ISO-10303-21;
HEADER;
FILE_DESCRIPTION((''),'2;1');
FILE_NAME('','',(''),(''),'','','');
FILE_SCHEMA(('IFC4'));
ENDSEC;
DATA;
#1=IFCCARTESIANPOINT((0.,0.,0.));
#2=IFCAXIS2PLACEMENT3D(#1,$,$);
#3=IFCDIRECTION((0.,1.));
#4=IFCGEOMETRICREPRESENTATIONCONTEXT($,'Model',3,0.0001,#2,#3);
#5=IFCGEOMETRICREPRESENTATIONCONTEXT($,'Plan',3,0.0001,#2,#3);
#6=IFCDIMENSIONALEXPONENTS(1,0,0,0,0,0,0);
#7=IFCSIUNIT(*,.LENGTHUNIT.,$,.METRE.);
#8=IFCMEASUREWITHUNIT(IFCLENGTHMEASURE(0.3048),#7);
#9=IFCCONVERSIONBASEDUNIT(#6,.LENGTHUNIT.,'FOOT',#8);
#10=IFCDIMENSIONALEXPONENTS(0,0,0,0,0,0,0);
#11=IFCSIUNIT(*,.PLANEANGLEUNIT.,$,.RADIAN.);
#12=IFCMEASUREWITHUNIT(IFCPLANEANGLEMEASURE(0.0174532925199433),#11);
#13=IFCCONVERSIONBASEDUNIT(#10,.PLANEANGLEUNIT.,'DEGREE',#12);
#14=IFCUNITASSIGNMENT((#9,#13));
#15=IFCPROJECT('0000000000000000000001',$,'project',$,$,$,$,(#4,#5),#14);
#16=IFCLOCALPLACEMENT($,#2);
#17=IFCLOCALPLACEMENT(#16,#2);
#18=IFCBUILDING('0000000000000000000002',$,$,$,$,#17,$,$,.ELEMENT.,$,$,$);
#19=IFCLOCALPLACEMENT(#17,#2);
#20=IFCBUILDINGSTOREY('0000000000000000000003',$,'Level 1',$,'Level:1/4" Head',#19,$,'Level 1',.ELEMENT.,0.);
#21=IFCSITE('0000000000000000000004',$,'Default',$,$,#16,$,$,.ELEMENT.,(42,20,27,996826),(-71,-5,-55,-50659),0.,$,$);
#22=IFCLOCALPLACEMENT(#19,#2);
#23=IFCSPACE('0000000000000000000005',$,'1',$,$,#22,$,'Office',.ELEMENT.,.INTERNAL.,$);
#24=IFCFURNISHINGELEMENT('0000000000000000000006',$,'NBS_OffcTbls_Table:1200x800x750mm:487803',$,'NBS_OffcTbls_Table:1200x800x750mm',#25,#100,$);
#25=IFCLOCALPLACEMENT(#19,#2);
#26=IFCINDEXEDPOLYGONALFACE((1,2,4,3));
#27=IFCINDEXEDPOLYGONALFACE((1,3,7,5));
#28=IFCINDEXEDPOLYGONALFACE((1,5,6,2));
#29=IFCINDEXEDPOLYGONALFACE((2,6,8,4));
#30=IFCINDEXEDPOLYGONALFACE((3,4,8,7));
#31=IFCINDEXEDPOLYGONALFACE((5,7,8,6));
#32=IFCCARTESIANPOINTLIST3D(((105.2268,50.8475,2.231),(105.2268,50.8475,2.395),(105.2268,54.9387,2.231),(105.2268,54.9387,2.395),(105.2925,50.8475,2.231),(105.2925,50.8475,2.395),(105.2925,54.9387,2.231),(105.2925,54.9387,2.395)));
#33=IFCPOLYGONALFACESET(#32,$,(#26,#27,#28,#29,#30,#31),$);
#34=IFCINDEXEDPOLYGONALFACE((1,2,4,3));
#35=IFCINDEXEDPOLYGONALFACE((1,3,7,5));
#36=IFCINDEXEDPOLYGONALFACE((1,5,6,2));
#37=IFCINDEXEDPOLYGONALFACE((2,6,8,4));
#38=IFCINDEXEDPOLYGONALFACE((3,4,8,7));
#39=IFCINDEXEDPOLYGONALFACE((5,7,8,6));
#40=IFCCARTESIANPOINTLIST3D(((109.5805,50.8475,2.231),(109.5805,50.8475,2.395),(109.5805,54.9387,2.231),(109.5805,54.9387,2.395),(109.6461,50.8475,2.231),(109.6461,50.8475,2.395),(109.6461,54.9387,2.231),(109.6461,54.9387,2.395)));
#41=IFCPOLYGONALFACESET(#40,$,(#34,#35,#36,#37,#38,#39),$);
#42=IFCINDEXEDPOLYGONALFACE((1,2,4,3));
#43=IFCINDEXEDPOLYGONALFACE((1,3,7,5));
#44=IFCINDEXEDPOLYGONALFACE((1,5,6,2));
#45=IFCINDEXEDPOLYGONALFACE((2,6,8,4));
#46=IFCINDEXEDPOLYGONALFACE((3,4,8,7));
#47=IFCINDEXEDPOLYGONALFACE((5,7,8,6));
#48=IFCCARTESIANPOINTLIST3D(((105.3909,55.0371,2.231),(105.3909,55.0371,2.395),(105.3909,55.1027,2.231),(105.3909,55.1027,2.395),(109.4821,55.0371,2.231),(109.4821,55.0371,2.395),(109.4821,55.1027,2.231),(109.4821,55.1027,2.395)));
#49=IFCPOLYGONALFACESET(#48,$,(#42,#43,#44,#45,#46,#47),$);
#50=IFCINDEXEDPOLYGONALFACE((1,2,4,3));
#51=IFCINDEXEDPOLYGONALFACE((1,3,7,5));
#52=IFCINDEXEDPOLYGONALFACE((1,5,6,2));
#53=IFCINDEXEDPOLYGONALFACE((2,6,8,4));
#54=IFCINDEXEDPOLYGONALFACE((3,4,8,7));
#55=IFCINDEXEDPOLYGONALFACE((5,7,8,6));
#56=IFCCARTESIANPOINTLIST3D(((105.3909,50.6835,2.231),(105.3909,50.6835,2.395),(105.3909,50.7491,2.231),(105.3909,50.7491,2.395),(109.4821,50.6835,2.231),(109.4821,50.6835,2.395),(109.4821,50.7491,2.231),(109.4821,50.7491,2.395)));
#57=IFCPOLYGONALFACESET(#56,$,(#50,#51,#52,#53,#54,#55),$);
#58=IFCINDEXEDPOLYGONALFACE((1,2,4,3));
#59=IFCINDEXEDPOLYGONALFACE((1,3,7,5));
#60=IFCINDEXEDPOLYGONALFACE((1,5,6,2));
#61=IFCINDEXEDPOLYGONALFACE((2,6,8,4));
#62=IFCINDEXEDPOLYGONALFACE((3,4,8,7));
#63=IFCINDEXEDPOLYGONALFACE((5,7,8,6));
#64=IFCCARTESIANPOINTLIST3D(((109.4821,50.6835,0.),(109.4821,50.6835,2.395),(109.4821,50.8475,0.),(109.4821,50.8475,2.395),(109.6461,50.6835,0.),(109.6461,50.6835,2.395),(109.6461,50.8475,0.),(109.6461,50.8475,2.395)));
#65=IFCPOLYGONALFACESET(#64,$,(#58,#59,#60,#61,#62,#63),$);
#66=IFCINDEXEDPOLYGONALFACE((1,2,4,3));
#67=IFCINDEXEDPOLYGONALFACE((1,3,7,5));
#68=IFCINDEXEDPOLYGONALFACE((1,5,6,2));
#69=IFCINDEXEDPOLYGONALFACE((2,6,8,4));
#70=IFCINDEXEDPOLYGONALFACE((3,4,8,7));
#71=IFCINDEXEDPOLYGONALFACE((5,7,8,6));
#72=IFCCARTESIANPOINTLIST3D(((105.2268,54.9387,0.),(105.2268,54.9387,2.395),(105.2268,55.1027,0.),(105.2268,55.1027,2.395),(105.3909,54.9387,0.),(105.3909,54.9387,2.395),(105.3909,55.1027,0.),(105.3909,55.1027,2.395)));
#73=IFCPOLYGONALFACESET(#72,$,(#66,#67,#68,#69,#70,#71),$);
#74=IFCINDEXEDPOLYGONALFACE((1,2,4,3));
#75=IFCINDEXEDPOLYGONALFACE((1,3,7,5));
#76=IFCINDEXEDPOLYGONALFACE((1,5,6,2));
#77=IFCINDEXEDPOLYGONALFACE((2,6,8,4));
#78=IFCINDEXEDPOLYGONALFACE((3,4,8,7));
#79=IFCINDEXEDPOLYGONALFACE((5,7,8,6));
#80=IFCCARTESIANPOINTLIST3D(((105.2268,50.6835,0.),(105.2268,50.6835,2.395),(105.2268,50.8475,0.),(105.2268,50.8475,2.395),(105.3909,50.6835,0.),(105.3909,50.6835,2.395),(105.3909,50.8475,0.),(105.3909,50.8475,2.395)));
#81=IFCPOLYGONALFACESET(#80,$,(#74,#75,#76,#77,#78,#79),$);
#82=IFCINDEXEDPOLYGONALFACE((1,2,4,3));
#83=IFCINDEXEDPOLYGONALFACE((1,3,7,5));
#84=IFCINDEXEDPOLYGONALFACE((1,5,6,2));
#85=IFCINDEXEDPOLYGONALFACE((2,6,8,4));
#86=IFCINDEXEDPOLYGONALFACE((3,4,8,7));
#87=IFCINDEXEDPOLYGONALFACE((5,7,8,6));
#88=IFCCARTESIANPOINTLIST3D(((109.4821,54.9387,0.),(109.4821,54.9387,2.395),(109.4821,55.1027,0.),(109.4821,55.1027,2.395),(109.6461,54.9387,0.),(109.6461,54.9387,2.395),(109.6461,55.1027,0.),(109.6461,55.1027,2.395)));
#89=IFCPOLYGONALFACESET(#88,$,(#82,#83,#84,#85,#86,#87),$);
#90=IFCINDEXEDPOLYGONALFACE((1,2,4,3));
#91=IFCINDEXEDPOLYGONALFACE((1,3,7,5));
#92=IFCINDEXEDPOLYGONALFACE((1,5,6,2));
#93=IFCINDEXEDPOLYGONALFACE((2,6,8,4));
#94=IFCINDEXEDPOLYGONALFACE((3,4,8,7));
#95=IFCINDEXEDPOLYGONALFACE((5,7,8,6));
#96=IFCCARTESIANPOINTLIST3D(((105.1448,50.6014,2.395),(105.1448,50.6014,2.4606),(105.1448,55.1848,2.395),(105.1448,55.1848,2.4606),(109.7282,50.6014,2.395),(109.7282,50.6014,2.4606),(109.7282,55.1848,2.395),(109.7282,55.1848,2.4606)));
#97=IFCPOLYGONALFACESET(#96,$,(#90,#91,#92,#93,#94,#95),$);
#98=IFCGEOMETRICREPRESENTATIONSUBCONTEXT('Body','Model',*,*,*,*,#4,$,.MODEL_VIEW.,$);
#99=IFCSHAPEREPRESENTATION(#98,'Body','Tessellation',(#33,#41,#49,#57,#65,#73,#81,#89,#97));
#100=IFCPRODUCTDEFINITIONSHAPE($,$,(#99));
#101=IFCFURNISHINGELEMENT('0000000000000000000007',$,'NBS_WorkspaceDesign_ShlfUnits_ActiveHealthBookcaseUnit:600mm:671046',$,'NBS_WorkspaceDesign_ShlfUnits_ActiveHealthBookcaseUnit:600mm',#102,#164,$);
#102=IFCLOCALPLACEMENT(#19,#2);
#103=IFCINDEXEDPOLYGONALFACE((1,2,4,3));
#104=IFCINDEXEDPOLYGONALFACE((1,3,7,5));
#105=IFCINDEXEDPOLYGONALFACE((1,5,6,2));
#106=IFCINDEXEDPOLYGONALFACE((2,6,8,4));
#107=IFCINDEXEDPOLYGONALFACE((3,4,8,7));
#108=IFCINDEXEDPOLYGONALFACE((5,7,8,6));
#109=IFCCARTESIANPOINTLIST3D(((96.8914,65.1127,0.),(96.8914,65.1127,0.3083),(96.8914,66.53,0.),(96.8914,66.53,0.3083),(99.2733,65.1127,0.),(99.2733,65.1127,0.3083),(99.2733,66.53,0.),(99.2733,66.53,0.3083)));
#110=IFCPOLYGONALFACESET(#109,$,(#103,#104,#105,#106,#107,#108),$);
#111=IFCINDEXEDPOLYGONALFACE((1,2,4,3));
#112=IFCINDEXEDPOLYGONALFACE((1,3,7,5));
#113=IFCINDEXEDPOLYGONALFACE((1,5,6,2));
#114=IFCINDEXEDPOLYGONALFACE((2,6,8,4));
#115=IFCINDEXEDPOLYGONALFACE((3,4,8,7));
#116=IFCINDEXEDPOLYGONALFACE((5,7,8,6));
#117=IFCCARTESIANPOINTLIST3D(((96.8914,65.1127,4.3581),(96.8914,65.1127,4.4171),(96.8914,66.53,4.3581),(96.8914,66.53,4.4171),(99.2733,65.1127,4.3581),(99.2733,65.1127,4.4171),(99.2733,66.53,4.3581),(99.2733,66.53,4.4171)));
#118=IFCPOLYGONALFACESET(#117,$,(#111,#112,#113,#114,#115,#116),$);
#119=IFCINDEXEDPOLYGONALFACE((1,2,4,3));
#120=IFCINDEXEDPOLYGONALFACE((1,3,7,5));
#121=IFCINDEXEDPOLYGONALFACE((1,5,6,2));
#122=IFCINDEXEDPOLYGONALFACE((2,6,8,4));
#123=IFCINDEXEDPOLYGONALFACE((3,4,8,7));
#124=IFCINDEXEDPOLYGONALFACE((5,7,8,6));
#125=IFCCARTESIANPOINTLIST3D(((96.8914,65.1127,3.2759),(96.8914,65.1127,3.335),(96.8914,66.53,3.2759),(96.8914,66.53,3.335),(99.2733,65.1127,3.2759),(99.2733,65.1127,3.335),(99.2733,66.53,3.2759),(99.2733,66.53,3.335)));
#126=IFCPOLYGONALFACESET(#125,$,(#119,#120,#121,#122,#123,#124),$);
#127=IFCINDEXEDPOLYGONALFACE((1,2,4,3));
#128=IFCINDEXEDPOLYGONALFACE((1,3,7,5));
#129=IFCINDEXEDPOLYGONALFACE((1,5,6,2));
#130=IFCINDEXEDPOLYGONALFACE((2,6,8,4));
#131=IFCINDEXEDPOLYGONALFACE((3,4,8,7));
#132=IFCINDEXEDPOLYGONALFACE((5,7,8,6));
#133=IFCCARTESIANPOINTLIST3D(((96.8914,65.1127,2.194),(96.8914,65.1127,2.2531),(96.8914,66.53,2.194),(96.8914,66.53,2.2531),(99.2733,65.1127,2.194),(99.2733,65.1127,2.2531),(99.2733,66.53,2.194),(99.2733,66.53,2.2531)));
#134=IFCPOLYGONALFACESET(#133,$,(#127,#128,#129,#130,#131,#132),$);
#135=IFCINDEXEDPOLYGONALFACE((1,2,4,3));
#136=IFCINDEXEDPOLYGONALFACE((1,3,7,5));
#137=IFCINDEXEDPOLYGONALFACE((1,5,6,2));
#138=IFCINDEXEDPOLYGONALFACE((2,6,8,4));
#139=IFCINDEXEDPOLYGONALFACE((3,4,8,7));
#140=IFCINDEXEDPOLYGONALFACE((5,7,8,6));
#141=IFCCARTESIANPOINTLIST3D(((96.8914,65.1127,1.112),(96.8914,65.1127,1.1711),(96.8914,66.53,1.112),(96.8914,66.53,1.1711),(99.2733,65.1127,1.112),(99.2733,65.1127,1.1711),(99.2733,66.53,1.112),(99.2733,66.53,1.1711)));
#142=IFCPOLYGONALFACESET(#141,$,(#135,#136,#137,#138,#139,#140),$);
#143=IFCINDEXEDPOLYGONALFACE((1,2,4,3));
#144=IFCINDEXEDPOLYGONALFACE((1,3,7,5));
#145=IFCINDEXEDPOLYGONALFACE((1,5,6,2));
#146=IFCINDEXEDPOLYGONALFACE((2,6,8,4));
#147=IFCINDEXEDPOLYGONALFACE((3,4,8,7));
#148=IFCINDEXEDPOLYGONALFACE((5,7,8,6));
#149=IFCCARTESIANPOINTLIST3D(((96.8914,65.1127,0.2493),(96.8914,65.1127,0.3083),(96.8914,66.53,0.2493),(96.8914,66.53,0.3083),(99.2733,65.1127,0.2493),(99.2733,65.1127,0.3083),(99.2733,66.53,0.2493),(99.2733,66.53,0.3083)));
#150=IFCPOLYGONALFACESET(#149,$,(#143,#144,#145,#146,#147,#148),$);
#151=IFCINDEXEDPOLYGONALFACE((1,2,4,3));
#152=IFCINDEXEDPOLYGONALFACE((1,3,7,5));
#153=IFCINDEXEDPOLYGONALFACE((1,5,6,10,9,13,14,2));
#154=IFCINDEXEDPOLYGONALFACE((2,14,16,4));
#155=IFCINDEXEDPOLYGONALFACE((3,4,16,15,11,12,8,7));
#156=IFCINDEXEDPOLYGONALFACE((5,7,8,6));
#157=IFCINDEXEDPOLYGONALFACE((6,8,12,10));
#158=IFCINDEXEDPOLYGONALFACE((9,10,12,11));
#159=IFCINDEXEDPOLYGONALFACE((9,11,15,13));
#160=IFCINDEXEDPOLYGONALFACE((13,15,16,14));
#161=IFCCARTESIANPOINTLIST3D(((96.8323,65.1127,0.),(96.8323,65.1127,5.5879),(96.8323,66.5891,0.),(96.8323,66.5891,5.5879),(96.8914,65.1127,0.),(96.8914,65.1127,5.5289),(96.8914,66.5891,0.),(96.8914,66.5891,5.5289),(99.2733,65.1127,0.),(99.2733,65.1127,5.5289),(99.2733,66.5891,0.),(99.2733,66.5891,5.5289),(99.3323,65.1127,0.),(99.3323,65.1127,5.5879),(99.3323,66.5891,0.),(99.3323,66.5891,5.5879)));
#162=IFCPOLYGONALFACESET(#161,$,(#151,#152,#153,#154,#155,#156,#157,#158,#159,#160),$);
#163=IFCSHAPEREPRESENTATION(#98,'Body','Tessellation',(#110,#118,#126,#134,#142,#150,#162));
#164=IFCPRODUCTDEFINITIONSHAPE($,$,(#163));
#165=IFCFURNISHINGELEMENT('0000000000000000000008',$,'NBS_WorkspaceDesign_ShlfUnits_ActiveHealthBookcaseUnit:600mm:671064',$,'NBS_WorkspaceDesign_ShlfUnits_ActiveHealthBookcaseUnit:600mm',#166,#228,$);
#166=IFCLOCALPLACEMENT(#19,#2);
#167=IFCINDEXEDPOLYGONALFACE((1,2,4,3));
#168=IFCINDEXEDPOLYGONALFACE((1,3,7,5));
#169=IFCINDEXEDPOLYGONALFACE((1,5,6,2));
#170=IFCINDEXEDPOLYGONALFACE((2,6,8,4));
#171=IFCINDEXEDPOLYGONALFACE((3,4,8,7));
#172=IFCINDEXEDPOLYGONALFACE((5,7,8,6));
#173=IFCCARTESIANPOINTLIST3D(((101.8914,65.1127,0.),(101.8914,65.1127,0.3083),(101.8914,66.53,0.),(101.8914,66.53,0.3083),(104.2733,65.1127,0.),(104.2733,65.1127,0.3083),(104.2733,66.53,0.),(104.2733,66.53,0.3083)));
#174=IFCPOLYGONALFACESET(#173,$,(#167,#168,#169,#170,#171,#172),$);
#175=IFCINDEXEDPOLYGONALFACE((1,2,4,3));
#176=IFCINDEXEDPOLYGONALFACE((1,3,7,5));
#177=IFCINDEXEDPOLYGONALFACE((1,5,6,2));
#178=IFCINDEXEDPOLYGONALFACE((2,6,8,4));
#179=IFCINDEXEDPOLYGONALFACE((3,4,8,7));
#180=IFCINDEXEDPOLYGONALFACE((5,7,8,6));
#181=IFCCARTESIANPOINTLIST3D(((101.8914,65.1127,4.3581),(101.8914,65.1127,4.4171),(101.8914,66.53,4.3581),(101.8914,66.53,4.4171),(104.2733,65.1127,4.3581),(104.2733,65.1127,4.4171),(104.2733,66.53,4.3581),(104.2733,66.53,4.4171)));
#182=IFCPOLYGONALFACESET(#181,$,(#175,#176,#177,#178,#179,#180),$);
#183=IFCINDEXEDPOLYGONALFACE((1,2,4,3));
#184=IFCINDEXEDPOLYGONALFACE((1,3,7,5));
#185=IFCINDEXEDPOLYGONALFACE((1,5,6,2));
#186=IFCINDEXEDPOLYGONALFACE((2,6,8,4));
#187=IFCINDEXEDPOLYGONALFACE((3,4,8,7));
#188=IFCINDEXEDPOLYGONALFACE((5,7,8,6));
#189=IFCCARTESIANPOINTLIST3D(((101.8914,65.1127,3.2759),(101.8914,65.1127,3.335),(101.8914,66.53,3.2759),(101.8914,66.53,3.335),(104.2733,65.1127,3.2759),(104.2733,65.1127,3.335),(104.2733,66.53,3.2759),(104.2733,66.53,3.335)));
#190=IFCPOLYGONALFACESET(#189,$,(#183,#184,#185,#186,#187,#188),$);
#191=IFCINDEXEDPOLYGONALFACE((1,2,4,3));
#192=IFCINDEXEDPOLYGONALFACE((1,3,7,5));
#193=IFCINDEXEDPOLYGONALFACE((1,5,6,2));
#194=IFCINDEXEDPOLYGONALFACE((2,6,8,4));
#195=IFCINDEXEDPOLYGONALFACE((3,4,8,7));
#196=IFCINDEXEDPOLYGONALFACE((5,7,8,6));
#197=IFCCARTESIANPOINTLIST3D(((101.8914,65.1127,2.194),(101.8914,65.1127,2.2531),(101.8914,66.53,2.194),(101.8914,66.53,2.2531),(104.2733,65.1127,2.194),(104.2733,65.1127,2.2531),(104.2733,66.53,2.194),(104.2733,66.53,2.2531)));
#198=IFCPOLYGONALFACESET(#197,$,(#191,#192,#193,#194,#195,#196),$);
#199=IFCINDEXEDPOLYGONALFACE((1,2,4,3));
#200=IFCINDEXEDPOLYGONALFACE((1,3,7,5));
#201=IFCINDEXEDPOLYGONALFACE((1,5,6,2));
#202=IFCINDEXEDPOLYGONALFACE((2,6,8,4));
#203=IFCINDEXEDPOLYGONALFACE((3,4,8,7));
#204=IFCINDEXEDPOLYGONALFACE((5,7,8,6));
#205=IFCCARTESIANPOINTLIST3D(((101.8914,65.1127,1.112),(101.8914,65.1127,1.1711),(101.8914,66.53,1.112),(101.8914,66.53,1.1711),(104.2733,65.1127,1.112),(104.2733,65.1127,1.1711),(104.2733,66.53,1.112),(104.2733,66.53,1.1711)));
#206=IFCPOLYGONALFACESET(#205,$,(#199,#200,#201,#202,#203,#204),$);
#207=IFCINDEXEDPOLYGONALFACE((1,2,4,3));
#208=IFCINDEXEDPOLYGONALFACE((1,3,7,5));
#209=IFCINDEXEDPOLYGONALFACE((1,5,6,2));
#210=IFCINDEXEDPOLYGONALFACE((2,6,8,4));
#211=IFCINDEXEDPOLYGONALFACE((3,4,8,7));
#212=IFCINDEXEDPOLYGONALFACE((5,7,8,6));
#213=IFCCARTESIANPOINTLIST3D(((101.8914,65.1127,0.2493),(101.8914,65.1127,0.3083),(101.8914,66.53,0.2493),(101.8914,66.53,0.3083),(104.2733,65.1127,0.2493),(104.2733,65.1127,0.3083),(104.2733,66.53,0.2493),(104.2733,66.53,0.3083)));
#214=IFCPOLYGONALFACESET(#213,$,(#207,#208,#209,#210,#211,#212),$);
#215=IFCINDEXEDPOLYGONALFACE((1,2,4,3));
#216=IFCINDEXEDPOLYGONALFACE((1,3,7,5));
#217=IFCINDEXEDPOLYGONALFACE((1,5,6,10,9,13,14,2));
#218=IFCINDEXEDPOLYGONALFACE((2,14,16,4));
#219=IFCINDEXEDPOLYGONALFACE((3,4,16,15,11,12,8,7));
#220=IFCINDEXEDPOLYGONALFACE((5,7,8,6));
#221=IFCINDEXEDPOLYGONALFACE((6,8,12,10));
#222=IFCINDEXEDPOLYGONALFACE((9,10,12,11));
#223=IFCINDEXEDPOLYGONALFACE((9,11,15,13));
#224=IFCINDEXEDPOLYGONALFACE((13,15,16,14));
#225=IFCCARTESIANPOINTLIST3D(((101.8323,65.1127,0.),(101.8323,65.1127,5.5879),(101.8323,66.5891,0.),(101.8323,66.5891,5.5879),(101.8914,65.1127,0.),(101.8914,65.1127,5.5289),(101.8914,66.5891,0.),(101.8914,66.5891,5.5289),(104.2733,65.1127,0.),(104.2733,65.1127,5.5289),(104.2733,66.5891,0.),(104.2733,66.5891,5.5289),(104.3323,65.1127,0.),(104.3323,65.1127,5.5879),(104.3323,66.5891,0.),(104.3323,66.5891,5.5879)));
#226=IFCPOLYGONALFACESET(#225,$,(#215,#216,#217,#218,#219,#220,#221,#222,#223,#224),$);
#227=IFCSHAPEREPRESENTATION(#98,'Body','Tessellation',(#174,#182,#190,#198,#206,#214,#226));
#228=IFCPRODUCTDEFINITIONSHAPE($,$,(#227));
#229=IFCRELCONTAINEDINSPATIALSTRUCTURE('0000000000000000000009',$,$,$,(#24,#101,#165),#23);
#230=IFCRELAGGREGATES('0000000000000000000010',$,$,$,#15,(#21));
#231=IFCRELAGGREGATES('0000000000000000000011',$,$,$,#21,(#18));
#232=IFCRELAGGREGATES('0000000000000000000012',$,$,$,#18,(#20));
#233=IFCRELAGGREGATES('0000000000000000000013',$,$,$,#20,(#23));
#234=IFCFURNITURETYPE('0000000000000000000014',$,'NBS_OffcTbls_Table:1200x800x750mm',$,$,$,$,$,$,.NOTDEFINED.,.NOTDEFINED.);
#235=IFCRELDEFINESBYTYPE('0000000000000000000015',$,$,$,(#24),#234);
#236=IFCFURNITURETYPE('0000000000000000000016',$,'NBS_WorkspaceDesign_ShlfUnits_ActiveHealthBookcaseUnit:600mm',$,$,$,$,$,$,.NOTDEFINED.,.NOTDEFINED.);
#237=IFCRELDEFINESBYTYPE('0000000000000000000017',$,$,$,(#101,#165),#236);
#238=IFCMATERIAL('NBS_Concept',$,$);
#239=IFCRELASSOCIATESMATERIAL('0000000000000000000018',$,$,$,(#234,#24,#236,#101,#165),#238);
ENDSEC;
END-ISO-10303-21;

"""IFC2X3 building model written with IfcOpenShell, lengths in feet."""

from ifc_helpers import new_model, entity, si_unit, converted_unit, direction, frame, frame_2d, origin, origin_2d_with_axis, place, context, subcontext, project, spatial, polyline, rectangle, outline, extrude, source, transform, mapped, material, type_object, type_shapes, element, save


model = new_model("IFC2X3")

# Units and contexts
model_context = context("Model", 3, precision=0.0001, world=origin(), true_north=direction((0.0, 1.0)))
plan_context = context("Plan", 3, precision=0.0001, world=origin(), true_north=direction((0.0, 1.0)))
body_context = subcontext(model_context, "Body", "Model", "MODEL_VIEW")
ifc_project = project(units=[converted_unit("LENGTHUNIT", "FOOT", entity("IfcLengthMeasure", 0.3048), si_unit("LENGTHUNIT", "METRE"), dimensions=[1, 0, 0, 0, 0, 0, 0]), converted_unit("PLANEANGLEUNIT", "DEGREE", entity("IfcPlaneAngleMeasure", 0.0174532925199433), si_unit("PLANEANGLEUNIT", "RADIAN"), dimensions=[0, 0, 0, 0, 0, 0, 0])], contexts=[model_context, plan_context])

# Site, building, storey
site_placement = place(None, origin())
site = spatial("IfcSite", under=ifc_project, at=site_placement, Name="Default", CompositionType="ELEMENT", RefLatitude=(42, 20, 27, 996826), RefLongitude=(-71, -5, -55, -50659), RefElevation=0.0)
building_placement = place(site_placement, origin())
building = spatial("IfcBuilding", under=site, at=building_placement, CompositionType="ELEMENT")
storey_placement = place(building_placement, origin())
storey = spatial("IfcBuildingStorey", under=building, at=storey_placement, Name="Level 1", ObjectType="Level:1/4\" Head", LongName="Level 1", CompositionType="ELEMENT", Elevation=0.0)

# Shared definitions
space_placement = place(storey_placement, origin())
space = spatial("IfcSpace", under=storey, at=space_placement, Name="1", LongName="Office", CompositionType="ELEMENT", InteriorOrExteriorSpace="INTERNAL")

# Furnishing elements
ifc_material_1 = material(Name="NBS_Concept")
furniture_type_1 = type_object("IfcFurnitureType", Name="NBS_OffcTbls_Table:1200x800x750mm", AssemblyPlace="NOTDEFINED", material=ifc_material_1)
shared_shape_1 = source(origin(), body_context, "Body", "SweptSolid", [
    extrude(rectangle(XDim=0.0656, YDim=4.0912, at=frame_2d((0.0, 0.0), x_axis=(1.0, 0.0))), frame((-2.1768, 0.0, 2.231)), (0.0, 0.0, 1.0), 0.164),
    extrude(rectangle(XDim=4.0912, YDim=0.0656, at=frame_2d((0.0, 0.0), x_axis=(1.0, 0.0))), frame((2.1768, 0.0, 2.231), z_axis=(0.0, 0.0, 1.0), x_axis=(0.0, -1.0, 0.0)), (0.0, 0.0, 1.0), 0.164),
    extrude(rectangle(XDim=4.0912, YDim=0.0656, at=origin_2d_with_axis()), frame((0.0, 2.1768, 2.231), z_axis=(0.0, 0.0, 1.0), x_axis=(-1.0, 0.0, 0.0)), (0.0, 0.0, 1.0), 0.164),
    extrude(rectangle(XDim=4.0912, YDim=0.0656, at=origin_2d_with_axis()), frame((0.0, -2.1768, 2.231)), (0.0, 0.0, 1.0), 0.164),
    extrude(rectangle(XDim=0.164, YDim=0.164, at=origin_2d_with_axis()), frame((2.1276, -2.1276, 0.0), z_axis=(0.0, 0.0, 1.0), x_axis=(-1.0, 0.0, 0.0)), (0.0, 0.0, 1.0), 2.395),
    extrude(rectangle(XDim=0.164, YDim=0.164, at=frame_2d((0.0, 0.0), x_axis=(1.0, 0.0))), frame((-2.1276, 2.1276, 0.0), z_axis=(0.0, 0.0, 1.0), x_axis=(-1.0, 0.0, 0.0)), (0.0, 0.0, 1.0), 2.395),
    extrude(rectangle(XDim=0.164, YDim=0.164, at=origin_2d_with_axis()), frame((-2.1276, -2.1276, 0.0), z_axis=(0.0, 0.0, 1.0), x_axis=(-1.0, 0.0, 0.0)), (0.0, 0.0, 1.0), 2.395),
    extrude(rectangle(XDim=0.164, YDim=0.164, at=frame_2d((0.0, 0.0), x_axis=(1.0, 0.0))), frame((2.1276, 2.1276, 0.0)), (0.0, 0.0, 1.0), 2.395),
    extrude(rectangle(XDim=4.5833, YDim=4.5833, at=origin_2d_with_axis()), frame((0.0, 0.0, 2.395)), (0.0, 0.0, 1.0), 0.0656),
])
type_shapes(furniture_type_1, [shared_shape_1])
for number, where, name in (
    (1, (107.4365, 52.8931, 0.0), "NBS_OffcTbls_Table:1200x800x750mm:487803"),
):
    element("IfcFurnishingElement", number, at=place(space_placement, frame(where)), inside=space, type_object=furniture_type_1, material=ifc_material_1, Name=name, ObjectType="NBS_OffcTbls_Table:1200x800x750mm", context=body_context, shape_type="MappedRepresentation", body=[
        mapped(shared_shape_1, transform((0.0, 0.0, 0.0), scale=1.0)),
    ])
furniture_type_2 = type_object("IfcFurnitureType", Name="NBS_WorkspaceDesign_ShlfUnits_ActiveHealthBookcaseUnit:600mm", AssemblyPlace="NOTDEFINED", material=ifc_material_1)
shared_shape_2 = source(origin(), body_context, "Body", "SweptSolid", [
    extrude(rectangle(XDim=1.4173, YDim=2.3819, at=frame_2d((0.0, 0.0), x_axis=(1.0, 0.0))), frame((0.0, -0.7677, 0.0), z_axis=(0.0, 0.0, 1.0), x_axis=(0.0, 1.0, 0.0)), (0.0, 0.0, 1.0), 0.3083),
    extrude(rectangle(XDim=1.4173, YDim=2.3819, at=frame_2d((0.0, 0.0), x_axis=(1.0, 0.0))), frame((0.0, -0.7677, 4.3581), z_axis=(0.0, 0.0, 1.0), x_axis=(0.0, 1.0, 0.0)), (0.0, 0.0, 1.0), 0.0591),
    extrude(rectangle(XDim=1.4173, YDim=2.3819, at=frame_2d((0.0, 0.0), x_axis=(1.0, 0.0))), frame((0.0, -0.7677, 3.2759), z_axis=(0.0, 0.0, 1.0), x_axis=(0.0, 1.0, 0.0)), (0.0, 0.0, 1.0), 0.0591),
    extrude(rectangle(XDim=1.4173, YDim=2.3819, at=frame_2d((0.0, 0.0), x_axis=(1.0, 0.0))), frame((0.0, -0.7677, 2.194), z_axis=(0.0, 0.0, 1.0), x_axis=(0.0, 1.0, 0.0)), (0.0, 0.0, 1.0), 0.0591),
    extrude(rectangle(XDim=1.4173, YDim=2.3819, at=frame_2d((0.0, 0.0), x_axis=(1.0, 0.0))), frame((0.0, -0.7677, 1.112), z_axis=(0.0, 0.0, 1.0), x_axis=(0.0, 1.0, 0.0)), (0.0, 0.0, 1.0), 0.0591),
    extrude(rectangle(XDim=1.4173, YDim=2.3819, at=frame_2d((0.0, 0.0), x_axis=(1.0, 0.0))), frame((0.0, -0.7677, 0.2493), z_axis=(0.0, 0.0, 1.0), x_axis=(0.0, 1.0, 0.0)), (0.0, 0.0, 1.0), 0.0591),
    extrude(outline(polyline([(-2.8087, -1.25), (2.7792, -1.25), (2.7792, -1.1909), (-2.7497, -1.1909), (-2.7497, 1.1909), (2.7792, 1.1909), (2.7792, 1.25), (-2.8087, 1.25), (-2.8087, -1.25)])), frame((0.0, -1.4764, 2.7792), z_axis=(0.0, 1.0, 0.0), x_axis=(0.0, 0.0, -1.0)), (0.0, 0.0, 1.0), 1.4764),
])
type_shapes(furniture_type_2, [shared_shape_2])
for number, where, name in (
    (2, (98.0823, 66.5891, 0.0), "NBS_WorkspaceDesign_ShlfUnits_ActiveHealthBookcaseUnit:600mm:671046"),
    (3, (103.0823, 66.5891, 0.0), "NBS_WorkspaceDesign_ShlfUnits_ActiveHealthBookcaseUnit:600mm:671064"),
):
    element("IfcFurnishingElement", number, at=place(space_placement, frame(where)), inside=space, type_object=furniture_type_2, material=ifc_material_1, Name=name, ObjectType="NBS_WorkspaceDesign_ShlfUnits_ActiveHealthBookcaseUnit:600mm", context=body_context, shape_type="MappedRepresentation", body=[
        mapped(shared_shape_2, transform((0.0, 0.0, 0.0), scale=1.0)),
    ])

save(model, "model.ifc")
